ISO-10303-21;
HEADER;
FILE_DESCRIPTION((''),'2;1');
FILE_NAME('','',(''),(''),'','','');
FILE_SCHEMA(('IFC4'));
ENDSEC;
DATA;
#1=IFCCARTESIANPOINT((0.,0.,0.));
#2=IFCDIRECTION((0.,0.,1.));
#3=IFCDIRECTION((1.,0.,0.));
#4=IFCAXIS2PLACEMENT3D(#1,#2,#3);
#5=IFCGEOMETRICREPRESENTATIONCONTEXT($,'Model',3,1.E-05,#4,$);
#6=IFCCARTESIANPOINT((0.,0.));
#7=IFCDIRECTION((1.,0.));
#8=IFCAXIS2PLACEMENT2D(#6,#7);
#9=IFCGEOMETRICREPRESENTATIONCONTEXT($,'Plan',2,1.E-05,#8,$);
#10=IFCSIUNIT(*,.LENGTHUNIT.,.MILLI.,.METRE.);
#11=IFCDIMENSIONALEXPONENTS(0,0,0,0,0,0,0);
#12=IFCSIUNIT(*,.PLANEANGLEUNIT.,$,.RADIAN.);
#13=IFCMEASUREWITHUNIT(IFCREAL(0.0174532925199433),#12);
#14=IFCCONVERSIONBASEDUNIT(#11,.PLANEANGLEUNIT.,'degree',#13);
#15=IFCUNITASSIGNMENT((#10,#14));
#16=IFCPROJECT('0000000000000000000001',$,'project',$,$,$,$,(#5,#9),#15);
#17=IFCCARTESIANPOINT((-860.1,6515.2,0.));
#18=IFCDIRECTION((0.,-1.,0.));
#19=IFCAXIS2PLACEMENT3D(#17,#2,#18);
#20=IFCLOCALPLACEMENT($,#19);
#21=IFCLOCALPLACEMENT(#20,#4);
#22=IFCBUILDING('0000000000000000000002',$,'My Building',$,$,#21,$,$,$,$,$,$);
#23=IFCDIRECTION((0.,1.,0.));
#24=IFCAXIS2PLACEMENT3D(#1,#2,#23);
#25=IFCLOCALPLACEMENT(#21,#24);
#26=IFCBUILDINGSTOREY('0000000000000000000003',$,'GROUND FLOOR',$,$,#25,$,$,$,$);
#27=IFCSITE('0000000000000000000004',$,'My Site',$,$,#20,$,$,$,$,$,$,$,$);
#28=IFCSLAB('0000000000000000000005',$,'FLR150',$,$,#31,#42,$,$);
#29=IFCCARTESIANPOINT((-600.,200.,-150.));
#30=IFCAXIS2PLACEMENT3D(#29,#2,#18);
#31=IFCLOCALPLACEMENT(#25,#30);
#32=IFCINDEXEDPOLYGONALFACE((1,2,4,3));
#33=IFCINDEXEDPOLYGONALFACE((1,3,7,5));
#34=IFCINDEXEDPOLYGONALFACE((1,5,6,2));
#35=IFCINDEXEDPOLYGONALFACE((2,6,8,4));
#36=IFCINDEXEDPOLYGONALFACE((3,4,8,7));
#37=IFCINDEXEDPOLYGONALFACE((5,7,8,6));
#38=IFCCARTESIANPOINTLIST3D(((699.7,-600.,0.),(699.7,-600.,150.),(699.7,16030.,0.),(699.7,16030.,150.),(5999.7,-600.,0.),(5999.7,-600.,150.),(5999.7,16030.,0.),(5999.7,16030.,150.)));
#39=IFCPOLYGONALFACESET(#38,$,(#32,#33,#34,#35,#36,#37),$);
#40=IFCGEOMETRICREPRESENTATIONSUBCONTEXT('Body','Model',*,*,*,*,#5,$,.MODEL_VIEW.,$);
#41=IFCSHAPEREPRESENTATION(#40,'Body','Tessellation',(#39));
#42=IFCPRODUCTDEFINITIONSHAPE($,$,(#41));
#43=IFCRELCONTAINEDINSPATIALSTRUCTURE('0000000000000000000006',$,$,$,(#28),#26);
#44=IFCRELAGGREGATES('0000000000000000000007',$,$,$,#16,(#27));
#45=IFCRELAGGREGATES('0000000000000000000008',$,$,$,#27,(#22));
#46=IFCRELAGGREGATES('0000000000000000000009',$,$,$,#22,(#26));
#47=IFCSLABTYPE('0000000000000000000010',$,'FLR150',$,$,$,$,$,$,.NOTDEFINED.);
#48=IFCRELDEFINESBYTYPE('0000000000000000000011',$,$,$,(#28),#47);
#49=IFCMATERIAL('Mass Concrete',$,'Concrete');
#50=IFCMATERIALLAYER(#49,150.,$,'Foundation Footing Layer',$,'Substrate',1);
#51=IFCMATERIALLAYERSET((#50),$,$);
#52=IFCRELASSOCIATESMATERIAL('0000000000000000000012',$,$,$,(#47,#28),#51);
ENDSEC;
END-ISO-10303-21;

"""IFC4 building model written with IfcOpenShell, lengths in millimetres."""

from ifc_helpers import new_model, entity, si_unit, converted_unit, frame, origin_with_axes, origin_2d_with_axis, place, context, subcontext, project, spatial, line, indexed_curve, outline, extrude, material, layer, layer_set, layer_usage, type_object, element, save


model = new_model("IFC4")

# Units and contexts
model_context = context("Model", 3, precision=1e-05, world=origin_with_axes())
plan_context = context("Plan", 2, precision=1e-05, world=origin_2d_with_axis())
body_context_1 = subcontext(model_context, "Body", "Model", "MODEL_VIEW")
ifc_project = project(units=[si_unit("LENGTHUNIT", "METRE", prefix="MILLI"), converted_unit("PLANEANGLEUNIT", "degree", entity("IfcReal", 0.0174532925199433), si_unit("PLANEANGLEUNIT", "RADIAN"), dimensions=[0, 0, 0, 0, 0, 0, 0])], contexts=[model_context, plan_context])

# Site, building, storey
site_placement = place(None, frame((-860.1, 6515.2, 0.0), z_axis=(0.0, 0.0, 1.0), x_axis=(0.0, -1.0, 0.0)))
site = spatial("IfcSite", under=ifc_project, at=site_placement, Name="My Site")
building_placement = place(site_placement, frame((0.0, 0.0, 0.0), z_axis=(0.0, 0.0, 1.0), x_axis=(1.0, 0.0, 0.0)))
building = spatial("IfcBuilding", under=site, at=building_placement, Name="My Building")
storey_placement = place(building_placement, frame((0.0, 0.0, 0.0), z_axis=(0.0, 0.0, 1.0), x_axis=(0.0, 1.0, 0.0)))
storey = spatial("IfcBuildingStorey", under=building, at=storey_placement, Name="GROUND FLOOR")

# Slab
ifc_material_1 = material(Name="Mass Concrete", Category="Concrete")
ifc_layer_1 = layer(ifc_material_1, 150.0, Name="Foundation Footing Layer", Category="Substrate", Priority=1)
ifc_layer_set_1 = layer_set([ifc_layer_1])
ifc_layer_usage_1 = layer_usage(ifc_layer_set_1, "AXIS3", "POSITIVE", 0.0)
slab_type = type_object("IfcSlabType", Name="FLR150", PredefinedType="NOTDEFINED", material=ifc_layer_set_1)
slab_placement = place(storey_placement, frame((-600.0, 200.0, -150.0), z_axis=(0.0, 0.0, 1.0), x_axis=(0.0, -1.0, 0.0)))
element("IfcSlab", 1, at=slab_placement, inside=storey, type_object=slab_type, material=ifc_layer_usage_1, Name="FLR150", context=body_context_1, shape_type="SweptSolid", body=[
    extrude(outline(indexed_curve([(699.7, -600.0), (5999.7, -600.0), (5999.7, 16030.0), (699.7, 16030.0)], segments=[line(3, 2), line(2, 1), line(1, 4), line(4, 3)], self_intersect=False)), None, (0.0, 0.0, 1.0), 150.0),
])

save(model, "model.ifc")
